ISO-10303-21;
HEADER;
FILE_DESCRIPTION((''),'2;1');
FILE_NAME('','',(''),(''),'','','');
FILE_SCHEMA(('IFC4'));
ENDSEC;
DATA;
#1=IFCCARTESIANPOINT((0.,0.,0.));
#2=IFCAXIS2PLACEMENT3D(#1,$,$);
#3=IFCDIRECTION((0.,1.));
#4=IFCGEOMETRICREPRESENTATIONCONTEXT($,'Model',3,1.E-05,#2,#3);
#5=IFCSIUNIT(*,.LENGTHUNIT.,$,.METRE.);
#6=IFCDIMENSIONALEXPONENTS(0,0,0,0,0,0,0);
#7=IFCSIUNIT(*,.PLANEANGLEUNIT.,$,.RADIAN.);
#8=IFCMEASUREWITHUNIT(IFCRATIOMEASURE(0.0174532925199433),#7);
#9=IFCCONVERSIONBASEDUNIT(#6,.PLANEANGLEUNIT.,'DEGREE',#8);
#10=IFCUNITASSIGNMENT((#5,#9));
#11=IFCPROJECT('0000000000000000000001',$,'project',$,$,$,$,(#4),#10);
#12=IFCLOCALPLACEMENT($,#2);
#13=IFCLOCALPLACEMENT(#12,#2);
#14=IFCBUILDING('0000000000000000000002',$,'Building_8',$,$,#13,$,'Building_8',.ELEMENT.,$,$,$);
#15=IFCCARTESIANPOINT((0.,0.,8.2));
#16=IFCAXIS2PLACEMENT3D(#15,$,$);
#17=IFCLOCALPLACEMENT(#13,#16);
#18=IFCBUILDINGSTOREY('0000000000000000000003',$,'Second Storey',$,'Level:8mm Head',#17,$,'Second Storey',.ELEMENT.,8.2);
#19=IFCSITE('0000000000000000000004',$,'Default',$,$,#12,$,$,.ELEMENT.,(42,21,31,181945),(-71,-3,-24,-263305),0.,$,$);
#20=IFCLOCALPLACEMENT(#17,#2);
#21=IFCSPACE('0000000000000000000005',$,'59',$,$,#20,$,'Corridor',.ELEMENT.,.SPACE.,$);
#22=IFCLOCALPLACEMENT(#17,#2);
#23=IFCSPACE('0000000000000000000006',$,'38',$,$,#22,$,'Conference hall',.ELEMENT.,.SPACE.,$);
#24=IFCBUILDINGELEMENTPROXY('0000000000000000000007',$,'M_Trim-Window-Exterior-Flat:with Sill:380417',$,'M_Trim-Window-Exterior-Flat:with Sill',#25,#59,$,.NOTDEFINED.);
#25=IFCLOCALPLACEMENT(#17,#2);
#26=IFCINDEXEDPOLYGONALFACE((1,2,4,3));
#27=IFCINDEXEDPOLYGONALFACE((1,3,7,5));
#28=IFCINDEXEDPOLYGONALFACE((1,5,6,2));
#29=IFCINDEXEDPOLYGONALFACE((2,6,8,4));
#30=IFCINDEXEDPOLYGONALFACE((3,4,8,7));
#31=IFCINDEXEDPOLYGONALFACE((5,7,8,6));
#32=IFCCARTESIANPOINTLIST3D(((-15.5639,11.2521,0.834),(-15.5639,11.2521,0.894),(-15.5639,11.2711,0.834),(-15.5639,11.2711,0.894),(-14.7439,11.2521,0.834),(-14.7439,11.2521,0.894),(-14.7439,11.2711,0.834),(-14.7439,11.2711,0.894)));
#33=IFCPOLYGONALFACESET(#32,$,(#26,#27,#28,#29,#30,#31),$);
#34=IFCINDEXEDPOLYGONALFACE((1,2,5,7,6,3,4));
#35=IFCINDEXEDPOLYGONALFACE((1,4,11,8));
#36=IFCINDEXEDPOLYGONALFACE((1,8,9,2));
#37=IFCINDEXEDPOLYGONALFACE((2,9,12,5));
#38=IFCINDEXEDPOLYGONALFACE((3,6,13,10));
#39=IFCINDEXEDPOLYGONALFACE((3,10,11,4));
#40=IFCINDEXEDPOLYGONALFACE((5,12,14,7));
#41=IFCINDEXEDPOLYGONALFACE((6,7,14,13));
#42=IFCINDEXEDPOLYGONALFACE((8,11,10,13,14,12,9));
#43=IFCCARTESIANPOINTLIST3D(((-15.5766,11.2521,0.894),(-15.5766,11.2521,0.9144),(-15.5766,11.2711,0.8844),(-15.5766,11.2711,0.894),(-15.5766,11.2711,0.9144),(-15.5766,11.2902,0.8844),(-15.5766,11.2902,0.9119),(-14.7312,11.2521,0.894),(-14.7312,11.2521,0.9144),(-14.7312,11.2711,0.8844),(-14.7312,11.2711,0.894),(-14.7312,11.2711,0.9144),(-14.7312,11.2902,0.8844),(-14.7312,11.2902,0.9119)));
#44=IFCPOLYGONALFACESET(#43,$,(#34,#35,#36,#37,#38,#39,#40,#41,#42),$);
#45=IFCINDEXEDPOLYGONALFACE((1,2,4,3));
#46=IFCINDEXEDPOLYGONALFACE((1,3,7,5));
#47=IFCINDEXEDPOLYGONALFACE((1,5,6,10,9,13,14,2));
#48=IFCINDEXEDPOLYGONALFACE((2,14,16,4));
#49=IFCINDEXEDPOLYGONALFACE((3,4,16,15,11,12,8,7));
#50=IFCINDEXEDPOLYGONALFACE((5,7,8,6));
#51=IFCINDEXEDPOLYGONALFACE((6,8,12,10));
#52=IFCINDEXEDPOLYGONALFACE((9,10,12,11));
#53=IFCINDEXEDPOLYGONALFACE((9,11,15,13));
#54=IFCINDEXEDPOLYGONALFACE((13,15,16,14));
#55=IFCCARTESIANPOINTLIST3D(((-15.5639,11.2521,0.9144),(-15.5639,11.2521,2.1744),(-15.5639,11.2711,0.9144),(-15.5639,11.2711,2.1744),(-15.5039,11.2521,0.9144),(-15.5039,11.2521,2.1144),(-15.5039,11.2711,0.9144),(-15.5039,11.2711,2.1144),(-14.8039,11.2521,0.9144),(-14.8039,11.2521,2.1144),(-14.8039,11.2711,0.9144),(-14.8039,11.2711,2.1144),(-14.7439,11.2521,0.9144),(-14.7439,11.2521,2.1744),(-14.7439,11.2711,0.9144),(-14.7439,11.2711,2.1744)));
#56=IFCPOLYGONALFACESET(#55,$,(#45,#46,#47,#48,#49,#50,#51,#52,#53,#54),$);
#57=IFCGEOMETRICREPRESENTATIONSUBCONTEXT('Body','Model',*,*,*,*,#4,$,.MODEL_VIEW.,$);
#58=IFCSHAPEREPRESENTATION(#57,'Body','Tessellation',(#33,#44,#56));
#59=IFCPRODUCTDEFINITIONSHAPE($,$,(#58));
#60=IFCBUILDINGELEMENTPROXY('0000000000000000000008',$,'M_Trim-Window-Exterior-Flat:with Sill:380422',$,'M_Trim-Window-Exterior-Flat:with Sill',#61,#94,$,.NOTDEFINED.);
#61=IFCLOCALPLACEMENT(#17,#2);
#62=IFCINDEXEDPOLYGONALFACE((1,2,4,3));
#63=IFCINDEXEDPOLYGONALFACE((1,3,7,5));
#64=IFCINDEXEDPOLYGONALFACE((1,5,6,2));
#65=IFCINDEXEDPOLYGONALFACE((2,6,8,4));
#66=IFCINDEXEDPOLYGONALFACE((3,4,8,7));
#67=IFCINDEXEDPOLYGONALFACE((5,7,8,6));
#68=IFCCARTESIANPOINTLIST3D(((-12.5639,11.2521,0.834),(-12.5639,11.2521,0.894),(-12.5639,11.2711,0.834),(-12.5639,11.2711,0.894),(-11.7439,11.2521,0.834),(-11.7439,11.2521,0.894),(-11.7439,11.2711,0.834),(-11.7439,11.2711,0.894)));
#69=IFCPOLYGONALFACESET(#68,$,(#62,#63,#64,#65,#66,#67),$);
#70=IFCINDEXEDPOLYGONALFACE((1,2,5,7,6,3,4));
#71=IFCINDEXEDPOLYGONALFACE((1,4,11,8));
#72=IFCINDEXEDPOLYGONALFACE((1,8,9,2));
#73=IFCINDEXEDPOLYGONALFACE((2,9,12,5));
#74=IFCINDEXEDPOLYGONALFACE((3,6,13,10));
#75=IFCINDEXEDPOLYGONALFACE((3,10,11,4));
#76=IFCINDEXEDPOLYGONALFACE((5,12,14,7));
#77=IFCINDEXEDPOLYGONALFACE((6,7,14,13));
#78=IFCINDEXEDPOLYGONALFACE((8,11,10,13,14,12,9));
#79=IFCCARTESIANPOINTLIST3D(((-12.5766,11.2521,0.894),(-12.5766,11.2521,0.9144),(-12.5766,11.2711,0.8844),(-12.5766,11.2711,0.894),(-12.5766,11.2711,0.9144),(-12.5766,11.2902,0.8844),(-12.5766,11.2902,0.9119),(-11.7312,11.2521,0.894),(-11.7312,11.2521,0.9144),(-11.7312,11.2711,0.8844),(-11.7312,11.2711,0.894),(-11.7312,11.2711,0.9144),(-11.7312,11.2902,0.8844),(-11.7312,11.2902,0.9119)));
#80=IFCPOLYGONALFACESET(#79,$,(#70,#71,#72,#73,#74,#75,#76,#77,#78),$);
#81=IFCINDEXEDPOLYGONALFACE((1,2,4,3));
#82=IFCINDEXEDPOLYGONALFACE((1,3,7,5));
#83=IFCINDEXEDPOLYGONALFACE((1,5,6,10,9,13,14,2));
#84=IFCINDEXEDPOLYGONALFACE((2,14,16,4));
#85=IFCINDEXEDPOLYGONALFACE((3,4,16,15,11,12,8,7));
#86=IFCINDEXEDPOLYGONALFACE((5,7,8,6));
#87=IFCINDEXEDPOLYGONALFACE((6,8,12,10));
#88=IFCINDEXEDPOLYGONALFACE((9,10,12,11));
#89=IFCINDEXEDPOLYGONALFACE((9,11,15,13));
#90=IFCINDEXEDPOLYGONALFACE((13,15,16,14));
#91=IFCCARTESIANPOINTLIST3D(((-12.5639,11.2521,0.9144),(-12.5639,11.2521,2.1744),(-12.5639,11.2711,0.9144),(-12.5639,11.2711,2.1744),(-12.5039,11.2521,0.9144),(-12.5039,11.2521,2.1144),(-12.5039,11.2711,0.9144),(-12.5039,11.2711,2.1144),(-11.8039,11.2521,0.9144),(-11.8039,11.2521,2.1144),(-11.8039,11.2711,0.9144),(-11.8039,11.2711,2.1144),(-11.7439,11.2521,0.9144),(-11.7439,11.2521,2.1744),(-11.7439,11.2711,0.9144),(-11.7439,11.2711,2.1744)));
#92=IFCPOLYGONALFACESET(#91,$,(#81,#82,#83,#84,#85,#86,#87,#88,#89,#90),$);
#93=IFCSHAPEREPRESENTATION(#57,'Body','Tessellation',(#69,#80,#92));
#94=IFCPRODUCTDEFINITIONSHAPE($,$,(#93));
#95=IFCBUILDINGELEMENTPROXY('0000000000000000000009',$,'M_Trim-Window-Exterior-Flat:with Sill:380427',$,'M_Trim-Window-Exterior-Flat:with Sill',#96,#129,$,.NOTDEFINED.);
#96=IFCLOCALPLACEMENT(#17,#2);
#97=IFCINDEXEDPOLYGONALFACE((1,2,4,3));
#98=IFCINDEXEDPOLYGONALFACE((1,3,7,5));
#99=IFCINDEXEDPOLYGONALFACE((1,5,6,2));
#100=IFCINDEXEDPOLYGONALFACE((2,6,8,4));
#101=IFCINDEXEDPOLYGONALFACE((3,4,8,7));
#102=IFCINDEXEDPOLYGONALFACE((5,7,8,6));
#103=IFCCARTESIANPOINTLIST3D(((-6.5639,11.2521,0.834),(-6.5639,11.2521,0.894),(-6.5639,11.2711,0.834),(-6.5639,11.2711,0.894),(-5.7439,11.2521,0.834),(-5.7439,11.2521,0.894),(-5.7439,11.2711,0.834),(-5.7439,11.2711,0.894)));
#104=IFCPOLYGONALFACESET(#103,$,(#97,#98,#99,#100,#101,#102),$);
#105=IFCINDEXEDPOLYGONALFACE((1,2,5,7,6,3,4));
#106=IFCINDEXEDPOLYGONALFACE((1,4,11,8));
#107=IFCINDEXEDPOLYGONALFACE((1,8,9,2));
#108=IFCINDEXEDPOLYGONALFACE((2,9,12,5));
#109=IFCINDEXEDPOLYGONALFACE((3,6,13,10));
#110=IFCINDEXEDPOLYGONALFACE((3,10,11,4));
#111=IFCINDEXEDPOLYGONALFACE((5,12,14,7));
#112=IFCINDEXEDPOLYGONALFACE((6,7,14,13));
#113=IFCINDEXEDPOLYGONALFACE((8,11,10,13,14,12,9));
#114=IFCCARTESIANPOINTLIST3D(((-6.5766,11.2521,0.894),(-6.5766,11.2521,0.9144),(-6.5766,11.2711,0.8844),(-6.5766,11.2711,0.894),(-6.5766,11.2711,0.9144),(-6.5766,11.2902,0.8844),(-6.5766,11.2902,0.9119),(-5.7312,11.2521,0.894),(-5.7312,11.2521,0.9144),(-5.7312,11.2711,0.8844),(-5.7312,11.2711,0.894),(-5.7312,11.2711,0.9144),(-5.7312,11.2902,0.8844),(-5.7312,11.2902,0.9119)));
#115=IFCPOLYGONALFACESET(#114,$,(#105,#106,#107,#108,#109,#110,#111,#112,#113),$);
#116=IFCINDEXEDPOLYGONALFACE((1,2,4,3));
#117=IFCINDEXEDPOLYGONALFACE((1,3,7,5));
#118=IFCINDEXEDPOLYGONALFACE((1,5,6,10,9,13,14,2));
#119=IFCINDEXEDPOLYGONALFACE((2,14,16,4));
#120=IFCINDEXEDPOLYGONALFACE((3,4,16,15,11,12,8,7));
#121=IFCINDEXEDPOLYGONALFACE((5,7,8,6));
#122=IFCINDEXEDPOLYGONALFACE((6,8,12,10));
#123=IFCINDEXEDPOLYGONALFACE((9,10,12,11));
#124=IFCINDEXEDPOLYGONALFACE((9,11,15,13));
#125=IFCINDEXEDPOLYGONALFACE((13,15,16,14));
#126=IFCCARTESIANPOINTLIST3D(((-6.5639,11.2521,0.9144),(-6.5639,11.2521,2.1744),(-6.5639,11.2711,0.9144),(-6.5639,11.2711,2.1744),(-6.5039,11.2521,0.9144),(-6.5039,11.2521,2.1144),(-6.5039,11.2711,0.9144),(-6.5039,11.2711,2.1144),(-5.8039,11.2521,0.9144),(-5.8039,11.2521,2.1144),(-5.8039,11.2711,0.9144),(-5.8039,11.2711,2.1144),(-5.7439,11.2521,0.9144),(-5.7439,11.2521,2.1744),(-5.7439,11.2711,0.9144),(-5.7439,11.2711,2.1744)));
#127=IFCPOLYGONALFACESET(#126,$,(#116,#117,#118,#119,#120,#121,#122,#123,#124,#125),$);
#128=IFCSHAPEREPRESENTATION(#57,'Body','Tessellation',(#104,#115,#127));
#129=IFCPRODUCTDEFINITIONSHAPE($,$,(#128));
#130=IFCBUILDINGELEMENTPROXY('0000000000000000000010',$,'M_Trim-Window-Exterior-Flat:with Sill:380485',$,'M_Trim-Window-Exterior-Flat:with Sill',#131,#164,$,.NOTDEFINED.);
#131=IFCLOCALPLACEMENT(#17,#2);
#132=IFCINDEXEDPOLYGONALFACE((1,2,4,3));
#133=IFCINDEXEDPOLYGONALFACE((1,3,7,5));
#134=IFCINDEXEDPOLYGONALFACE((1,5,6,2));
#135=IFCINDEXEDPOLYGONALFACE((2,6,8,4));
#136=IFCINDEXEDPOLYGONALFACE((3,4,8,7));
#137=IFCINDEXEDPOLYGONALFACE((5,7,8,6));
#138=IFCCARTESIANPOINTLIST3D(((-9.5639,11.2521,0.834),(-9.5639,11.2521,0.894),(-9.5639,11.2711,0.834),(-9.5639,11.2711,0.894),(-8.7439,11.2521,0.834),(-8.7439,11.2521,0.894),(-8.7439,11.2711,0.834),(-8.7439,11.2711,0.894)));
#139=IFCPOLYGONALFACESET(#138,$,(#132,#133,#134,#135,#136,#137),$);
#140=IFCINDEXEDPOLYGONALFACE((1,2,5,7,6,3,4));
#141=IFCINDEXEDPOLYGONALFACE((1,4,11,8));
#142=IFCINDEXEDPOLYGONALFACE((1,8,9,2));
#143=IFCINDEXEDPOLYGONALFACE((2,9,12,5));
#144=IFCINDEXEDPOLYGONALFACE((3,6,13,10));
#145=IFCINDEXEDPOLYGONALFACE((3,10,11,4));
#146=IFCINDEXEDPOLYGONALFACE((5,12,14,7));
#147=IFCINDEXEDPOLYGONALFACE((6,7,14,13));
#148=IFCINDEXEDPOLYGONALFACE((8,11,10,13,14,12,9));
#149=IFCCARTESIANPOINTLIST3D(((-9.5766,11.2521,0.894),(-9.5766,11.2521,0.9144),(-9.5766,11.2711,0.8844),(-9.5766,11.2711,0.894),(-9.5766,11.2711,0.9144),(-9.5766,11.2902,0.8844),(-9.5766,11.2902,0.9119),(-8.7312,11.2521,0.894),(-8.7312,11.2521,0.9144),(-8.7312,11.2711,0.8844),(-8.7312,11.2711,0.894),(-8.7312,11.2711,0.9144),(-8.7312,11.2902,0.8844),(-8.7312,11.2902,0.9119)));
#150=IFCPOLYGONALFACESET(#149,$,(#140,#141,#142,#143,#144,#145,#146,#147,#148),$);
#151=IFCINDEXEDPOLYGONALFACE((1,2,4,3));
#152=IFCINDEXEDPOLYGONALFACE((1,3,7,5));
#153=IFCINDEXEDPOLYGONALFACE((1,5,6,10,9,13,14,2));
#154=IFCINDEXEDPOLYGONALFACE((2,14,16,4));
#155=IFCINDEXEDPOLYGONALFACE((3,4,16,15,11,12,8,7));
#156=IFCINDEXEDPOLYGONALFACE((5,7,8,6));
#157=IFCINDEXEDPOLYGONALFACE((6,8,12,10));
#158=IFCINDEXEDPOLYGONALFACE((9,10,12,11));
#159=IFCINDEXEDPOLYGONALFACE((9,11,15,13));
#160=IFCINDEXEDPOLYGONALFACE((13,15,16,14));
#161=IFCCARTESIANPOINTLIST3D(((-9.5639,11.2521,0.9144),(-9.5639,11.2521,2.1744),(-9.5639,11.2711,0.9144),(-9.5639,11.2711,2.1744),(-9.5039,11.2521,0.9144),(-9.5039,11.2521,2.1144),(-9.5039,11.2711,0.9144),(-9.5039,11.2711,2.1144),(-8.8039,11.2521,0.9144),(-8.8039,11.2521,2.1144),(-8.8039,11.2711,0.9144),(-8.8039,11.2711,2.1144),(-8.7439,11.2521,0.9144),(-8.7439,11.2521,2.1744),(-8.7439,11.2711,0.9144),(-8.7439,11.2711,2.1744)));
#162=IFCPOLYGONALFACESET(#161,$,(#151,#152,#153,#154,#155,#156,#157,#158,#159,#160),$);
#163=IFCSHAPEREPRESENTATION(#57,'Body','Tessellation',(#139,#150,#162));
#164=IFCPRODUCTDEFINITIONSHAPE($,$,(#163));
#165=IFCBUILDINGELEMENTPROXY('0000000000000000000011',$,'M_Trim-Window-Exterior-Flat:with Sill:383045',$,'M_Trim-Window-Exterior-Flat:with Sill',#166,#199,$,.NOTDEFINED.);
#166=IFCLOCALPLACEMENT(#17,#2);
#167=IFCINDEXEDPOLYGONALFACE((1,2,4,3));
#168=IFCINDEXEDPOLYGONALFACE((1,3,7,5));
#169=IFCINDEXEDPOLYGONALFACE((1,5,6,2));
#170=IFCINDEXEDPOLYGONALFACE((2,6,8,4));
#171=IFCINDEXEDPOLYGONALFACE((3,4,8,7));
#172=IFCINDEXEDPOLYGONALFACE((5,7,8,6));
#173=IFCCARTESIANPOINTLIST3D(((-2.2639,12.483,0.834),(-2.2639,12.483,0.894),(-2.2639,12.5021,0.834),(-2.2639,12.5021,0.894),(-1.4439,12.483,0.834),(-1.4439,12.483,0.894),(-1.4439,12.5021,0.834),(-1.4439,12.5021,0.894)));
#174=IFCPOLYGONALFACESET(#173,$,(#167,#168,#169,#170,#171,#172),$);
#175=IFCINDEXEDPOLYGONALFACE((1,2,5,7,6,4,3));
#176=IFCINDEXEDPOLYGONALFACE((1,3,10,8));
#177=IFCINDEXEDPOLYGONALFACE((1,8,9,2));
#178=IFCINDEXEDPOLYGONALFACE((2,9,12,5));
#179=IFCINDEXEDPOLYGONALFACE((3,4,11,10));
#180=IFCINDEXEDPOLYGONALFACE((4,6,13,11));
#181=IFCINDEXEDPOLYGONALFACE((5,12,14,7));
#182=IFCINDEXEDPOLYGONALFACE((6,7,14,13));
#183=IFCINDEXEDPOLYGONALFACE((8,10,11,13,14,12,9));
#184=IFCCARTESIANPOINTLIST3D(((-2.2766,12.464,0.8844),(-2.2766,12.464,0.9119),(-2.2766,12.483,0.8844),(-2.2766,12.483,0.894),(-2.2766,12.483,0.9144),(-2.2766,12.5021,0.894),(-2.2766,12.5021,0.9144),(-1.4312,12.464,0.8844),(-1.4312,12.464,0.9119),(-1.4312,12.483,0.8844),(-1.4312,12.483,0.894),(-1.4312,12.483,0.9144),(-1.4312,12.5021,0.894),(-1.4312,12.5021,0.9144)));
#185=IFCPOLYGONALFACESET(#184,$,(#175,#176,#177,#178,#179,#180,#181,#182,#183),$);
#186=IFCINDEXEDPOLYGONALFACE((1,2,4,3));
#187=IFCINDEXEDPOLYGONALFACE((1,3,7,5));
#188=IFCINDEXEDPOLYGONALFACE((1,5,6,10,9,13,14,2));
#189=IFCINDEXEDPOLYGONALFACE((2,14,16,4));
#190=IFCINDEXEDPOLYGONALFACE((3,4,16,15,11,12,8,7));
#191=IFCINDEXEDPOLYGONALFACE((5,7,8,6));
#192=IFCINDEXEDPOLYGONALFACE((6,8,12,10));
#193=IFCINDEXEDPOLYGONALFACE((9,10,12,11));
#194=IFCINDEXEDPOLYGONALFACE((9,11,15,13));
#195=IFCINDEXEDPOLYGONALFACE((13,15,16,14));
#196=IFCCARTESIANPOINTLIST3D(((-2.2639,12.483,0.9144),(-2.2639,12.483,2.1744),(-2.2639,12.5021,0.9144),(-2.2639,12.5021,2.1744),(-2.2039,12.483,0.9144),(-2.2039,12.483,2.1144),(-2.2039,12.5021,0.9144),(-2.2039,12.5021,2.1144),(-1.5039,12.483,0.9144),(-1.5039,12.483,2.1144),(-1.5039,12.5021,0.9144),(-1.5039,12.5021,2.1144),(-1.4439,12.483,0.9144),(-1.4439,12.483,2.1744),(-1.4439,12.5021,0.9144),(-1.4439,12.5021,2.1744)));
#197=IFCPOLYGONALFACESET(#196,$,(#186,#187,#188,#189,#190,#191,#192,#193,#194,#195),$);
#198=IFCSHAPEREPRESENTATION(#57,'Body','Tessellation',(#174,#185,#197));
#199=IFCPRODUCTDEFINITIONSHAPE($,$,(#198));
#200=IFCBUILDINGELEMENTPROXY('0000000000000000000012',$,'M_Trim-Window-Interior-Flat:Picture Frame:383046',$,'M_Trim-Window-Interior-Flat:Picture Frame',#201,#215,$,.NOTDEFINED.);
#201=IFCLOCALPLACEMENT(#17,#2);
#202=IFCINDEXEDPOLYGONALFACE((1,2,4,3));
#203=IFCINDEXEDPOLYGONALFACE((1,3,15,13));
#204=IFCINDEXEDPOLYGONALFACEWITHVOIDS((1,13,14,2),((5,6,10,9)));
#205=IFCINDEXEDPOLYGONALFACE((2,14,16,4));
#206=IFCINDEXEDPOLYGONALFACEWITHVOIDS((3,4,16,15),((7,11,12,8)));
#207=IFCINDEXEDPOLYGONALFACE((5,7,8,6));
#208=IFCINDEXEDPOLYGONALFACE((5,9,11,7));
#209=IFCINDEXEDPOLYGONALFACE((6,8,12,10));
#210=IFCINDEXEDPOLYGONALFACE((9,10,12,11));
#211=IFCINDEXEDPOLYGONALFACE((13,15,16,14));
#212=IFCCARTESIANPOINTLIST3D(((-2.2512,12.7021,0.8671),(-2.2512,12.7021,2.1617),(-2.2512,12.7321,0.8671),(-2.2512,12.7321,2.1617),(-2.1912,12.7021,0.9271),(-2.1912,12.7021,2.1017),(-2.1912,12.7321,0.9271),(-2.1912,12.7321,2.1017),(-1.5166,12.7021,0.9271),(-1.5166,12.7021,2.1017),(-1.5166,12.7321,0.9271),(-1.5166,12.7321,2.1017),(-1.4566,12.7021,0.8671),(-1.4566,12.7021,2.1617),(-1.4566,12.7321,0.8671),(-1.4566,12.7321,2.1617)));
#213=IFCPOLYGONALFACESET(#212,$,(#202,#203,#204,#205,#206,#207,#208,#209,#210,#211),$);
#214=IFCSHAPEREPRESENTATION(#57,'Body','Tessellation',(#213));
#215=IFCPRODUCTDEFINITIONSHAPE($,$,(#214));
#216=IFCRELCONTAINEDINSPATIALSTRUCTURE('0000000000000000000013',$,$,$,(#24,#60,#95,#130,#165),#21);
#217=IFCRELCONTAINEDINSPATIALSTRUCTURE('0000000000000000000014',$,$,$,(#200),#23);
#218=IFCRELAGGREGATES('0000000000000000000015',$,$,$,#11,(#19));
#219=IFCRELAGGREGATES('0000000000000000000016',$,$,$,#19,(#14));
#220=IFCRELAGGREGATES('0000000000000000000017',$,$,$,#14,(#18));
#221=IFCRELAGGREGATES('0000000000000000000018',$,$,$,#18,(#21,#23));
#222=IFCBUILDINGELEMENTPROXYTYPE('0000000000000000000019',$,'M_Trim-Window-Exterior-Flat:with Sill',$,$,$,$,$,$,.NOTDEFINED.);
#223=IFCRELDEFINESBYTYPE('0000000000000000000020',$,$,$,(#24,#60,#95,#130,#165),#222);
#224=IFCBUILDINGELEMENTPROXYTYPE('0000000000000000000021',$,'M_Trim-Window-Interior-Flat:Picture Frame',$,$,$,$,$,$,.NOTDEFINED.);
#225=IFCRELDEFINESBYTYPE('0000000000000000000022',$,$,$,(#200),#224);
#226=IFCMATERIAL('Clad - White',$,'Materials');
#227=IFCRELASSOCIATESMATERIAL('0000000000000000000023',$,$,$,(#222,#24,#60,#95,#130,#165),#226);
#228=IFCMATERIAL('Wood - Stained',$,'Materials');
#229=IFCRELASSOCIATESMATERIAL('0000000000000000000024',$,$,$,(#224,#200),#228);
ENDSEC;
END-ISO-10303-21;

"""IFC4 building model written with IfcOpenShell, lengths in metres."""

from ifc_helpers import new_model, entity, si_unit, converted_unit, direction, frame, origin, place, context, subcontext, project, spatial, indexed_curve, outline, extrude, source, transform, mapped, material, type_object, type_shapes, element, save


model = new_model("IFC4")

# Units and contexts
model_context = context("Model", 3, precision=1e-05, world=origin(), true_north=direction((0.0, 1.0)))
body_context = subcontext(model_context, "Body", "Model", "MODEL_VIEW")
ifc_project = project(units=[si_unit("LENGTHUNIT", "METRE"), converted_unit("PLANEANGLEUNIT", "DEGREE", entity("IfcRatioMeasure", 0.0174532925199433), si_unit("PLANEANGLEUNIT", "RADIAN"), dimensions=[0, 0, 0, 0, 0, 0, 0])], contexts=[model_context])

# Site, building, storey
site_placement = place(None, origin())
site = spatial("IfcSite", under=ifc_project, at=site_placement, Name="Default", CompositionType="ELEMENT", RefLatitude=(42, 21, 31, 181945), RefLongitude=(-71, -3, -24, -263305), RefElevation=0.0)
building_placement = place(site_placement, origin())
building = spatial("IfcBuilding", under=site, at=building_placement, Name="Building_8", LongName="Building_8", CompositionType="ELEMENT")
storey_placement = place(building_placement, frame((0.0, 0.0, 8.2)))
storey = spatial("IfcBuildingStorey", under=building, at=storey_placement, Name="Second Storey", ObjectType="Level:8mm Head", LongName="Second Storey", CompositionType="ELEMENT", Elevation=8.2)

# Shared definitions
ifc_material_1 = material(Name="Clad - White", Category="Materials")
ifc_material_2 = material(Name="Wood - Stained", Category="Materials")

# Shared definitions
space_1_placement = place(storey_placement, origin())
space_1 = spatial("IfcSpace", under=storey, at=space_1_placement, Name="59", LongName="Corridor", CompositionType="ELEMENT", PredefinedType="SPACE")

# Building element proxies
building_element_proxy_type_1 = type_object("IfcBuildingElementProxyType", Name="M_Trim-Window-Exterior-Flat:with Sill", PredefinedType="NOTDEFINED", material=ifc_material_1)
shared_shape_1 = source(origin(), body_context, "Body", "SweptSolid", [
    extrude(outline(indexed_curve([(-0.03, -0.41), (0.03, -0.41), (0.03, 0.41), (-0.03, 0.41), (-0.03, -0.41)], self_intersect=False)), frame((0.0, 1.2504, 0.0), z_axis=(0.0, 0.0, 1.0), x_axis=(0.0, 1.0, 0.0)), (0.0, 0.0, 1.0), 0.0191),
    extrude(outline(indexed_curve([(-0.0152, -0.019), (0.0123, -0.019), (0.0148, 0.0), (0.0148, 0.019), (-0.0057, 0.019), (-0.0057, 0.0), (-0.0152, 0.0), (-0.0152, -0.019)], self_intersect=False)), frame((-0.4227, 1.2148, 0.019), z_axis=(1.0, 0.0, 0.0), x_axis=(0.0, -1.0, 0.0)), (0.0, 0.0, 1.0), 0.8454),
    extrude(outline(indexed_curve([(-0.41, -0.645), (0.41, -0.645), (0.41, 0.615), (0.35, 0.615), (0.35, -0.585), (-0.35, -0.585), (-0.35, 0.615), (-0.41, 0.615), (-0.41, -0.645)], self_intersect=False)), frame((0.0, 0.585, 0.0)), (0.0, 0.0, 1.0), 0.0191),
])
type_shapes(building_element_proxy_type_1, [shared_shape_1])
for number, where, z_axis, x_axis, name in (
    (1, (-15.1539, 11.2521, 2.1144), (0.0, 1.0, 0.0), (1.0, 0.0, 0.0), "M_Trim-Window-Exterior-Flat:with Sill:380417"),
    (2, (-12.1539, 11.2521, 2.1144), (0.0, 1.0, 0.0), (1.0, 0.0, 0.0), "M_Trim-Window-Exterior-Flat:with Sill:380422"),
    (3, (-6.1539, 11.2521, 2.1144), (0.0, 1.0, 0.0), (1.0, 0.0, 0.0), "M_Trim-Window-Exterior-Flat:with Sill:380427"),
    (4, (-9.1539, 11.2521, 2.1144), (0.0, 1.0, 0.0), (1.0, 0.0, 0.0), "M_Trim-Window-Exterior-Flat:with Sill:380485"),
    (5, (-1.8539, 12.5021, 2.1144), (0.0, -1.0, 0.0), (-1.0, 0.0, 0.0), "M_Trim-Window-Exterior-Flat:with Sill:383045"),
):
    element("IfcBuildingElementProxy", number, at=place(space_1_placement, frame(where, z_axis=z_axis, x_axis=x_axis)), inside=space_1, type_object=building_element_proxy_type_1, material=ifc_material_1, Name=name, ObjectType="M_Trim-Window-Exterior-Flat:with Sill", PredefinedType="NOTDEFINED", context=body_context, shape_type="MappedRepresentation", body=[
        mapped(shared_shape_1, transform((0.0, 0.0, 0.0), scale=1.0)),
    ])

# Shared definitions
space_2_placement = place(storey_placement, origin())
space_2 = spatial("IfcSpace", under=storey, at=space_2_placement, Name="38", LongName="Conference hall", CompositionType="ELEMENT", PredefinedType="SPACE")

# Building element proxy
building_element_proxy_type_2 = type_object("IfcBuildingElementProxyType", Name="M_Trim-Window-Interior-Flat:Picture Frame", PredefinedType="NOTDEFINED", material=ifc_material_2)
shared_shape_2 = source(origin(), body_context, "Body", "SweptSolid", [
    extrude(outline(indexed_curve([(-0.6473, -0.3973), (0.6473, -0.3973), (0.6473, 0.3973), (-0.6473, 0.3973), (-0.6473, -0.3973)], self_intersect=False), holes=[indexed_curve([(-0.5873, -0.3373), (-0.5873, 0.3373), (0.5873, 0.3373), (0.5873, -0.3373), (-0.5873, -0.3373)], self_intersect=False)]), frame((0.0, 0.6, 0.0), z_axis=(0.0, 0.0, 1.0), x_axis=(0.0, 1.0, 0.0)), (0.0, 0.0, 1.0), 0.03),
])
type_shapes(building_element_proxy_type_2, [shared_shape_2])
proxy_1_placement = place(space_2_placement, frame((-1.8539, 12.7021, 2.1144), z_axis=(0.0, 1.0, 0.0), x_axis=(1.0, 0.0, 0.0)))
element("IfcBuildingElementProxy", 6, at=proxy_1_placement, inside=space_2, type_object=building_element_proxy_type_2, material=ifc_material_2, Name="M_Trim-Window-Interior-Flat:Picture Frame:383046", ObjectType="M_Trim-Window-Interior-Flat:Picture Frame", PredefinedType="NOTDEFINED", context=body_context, shape_type="MappedRepresentation", body=[
    mapped(shared_shape_2, transform((0.0, 0.0, 0.0), scale=1.0)),
])

save(model, "model.ifc")
